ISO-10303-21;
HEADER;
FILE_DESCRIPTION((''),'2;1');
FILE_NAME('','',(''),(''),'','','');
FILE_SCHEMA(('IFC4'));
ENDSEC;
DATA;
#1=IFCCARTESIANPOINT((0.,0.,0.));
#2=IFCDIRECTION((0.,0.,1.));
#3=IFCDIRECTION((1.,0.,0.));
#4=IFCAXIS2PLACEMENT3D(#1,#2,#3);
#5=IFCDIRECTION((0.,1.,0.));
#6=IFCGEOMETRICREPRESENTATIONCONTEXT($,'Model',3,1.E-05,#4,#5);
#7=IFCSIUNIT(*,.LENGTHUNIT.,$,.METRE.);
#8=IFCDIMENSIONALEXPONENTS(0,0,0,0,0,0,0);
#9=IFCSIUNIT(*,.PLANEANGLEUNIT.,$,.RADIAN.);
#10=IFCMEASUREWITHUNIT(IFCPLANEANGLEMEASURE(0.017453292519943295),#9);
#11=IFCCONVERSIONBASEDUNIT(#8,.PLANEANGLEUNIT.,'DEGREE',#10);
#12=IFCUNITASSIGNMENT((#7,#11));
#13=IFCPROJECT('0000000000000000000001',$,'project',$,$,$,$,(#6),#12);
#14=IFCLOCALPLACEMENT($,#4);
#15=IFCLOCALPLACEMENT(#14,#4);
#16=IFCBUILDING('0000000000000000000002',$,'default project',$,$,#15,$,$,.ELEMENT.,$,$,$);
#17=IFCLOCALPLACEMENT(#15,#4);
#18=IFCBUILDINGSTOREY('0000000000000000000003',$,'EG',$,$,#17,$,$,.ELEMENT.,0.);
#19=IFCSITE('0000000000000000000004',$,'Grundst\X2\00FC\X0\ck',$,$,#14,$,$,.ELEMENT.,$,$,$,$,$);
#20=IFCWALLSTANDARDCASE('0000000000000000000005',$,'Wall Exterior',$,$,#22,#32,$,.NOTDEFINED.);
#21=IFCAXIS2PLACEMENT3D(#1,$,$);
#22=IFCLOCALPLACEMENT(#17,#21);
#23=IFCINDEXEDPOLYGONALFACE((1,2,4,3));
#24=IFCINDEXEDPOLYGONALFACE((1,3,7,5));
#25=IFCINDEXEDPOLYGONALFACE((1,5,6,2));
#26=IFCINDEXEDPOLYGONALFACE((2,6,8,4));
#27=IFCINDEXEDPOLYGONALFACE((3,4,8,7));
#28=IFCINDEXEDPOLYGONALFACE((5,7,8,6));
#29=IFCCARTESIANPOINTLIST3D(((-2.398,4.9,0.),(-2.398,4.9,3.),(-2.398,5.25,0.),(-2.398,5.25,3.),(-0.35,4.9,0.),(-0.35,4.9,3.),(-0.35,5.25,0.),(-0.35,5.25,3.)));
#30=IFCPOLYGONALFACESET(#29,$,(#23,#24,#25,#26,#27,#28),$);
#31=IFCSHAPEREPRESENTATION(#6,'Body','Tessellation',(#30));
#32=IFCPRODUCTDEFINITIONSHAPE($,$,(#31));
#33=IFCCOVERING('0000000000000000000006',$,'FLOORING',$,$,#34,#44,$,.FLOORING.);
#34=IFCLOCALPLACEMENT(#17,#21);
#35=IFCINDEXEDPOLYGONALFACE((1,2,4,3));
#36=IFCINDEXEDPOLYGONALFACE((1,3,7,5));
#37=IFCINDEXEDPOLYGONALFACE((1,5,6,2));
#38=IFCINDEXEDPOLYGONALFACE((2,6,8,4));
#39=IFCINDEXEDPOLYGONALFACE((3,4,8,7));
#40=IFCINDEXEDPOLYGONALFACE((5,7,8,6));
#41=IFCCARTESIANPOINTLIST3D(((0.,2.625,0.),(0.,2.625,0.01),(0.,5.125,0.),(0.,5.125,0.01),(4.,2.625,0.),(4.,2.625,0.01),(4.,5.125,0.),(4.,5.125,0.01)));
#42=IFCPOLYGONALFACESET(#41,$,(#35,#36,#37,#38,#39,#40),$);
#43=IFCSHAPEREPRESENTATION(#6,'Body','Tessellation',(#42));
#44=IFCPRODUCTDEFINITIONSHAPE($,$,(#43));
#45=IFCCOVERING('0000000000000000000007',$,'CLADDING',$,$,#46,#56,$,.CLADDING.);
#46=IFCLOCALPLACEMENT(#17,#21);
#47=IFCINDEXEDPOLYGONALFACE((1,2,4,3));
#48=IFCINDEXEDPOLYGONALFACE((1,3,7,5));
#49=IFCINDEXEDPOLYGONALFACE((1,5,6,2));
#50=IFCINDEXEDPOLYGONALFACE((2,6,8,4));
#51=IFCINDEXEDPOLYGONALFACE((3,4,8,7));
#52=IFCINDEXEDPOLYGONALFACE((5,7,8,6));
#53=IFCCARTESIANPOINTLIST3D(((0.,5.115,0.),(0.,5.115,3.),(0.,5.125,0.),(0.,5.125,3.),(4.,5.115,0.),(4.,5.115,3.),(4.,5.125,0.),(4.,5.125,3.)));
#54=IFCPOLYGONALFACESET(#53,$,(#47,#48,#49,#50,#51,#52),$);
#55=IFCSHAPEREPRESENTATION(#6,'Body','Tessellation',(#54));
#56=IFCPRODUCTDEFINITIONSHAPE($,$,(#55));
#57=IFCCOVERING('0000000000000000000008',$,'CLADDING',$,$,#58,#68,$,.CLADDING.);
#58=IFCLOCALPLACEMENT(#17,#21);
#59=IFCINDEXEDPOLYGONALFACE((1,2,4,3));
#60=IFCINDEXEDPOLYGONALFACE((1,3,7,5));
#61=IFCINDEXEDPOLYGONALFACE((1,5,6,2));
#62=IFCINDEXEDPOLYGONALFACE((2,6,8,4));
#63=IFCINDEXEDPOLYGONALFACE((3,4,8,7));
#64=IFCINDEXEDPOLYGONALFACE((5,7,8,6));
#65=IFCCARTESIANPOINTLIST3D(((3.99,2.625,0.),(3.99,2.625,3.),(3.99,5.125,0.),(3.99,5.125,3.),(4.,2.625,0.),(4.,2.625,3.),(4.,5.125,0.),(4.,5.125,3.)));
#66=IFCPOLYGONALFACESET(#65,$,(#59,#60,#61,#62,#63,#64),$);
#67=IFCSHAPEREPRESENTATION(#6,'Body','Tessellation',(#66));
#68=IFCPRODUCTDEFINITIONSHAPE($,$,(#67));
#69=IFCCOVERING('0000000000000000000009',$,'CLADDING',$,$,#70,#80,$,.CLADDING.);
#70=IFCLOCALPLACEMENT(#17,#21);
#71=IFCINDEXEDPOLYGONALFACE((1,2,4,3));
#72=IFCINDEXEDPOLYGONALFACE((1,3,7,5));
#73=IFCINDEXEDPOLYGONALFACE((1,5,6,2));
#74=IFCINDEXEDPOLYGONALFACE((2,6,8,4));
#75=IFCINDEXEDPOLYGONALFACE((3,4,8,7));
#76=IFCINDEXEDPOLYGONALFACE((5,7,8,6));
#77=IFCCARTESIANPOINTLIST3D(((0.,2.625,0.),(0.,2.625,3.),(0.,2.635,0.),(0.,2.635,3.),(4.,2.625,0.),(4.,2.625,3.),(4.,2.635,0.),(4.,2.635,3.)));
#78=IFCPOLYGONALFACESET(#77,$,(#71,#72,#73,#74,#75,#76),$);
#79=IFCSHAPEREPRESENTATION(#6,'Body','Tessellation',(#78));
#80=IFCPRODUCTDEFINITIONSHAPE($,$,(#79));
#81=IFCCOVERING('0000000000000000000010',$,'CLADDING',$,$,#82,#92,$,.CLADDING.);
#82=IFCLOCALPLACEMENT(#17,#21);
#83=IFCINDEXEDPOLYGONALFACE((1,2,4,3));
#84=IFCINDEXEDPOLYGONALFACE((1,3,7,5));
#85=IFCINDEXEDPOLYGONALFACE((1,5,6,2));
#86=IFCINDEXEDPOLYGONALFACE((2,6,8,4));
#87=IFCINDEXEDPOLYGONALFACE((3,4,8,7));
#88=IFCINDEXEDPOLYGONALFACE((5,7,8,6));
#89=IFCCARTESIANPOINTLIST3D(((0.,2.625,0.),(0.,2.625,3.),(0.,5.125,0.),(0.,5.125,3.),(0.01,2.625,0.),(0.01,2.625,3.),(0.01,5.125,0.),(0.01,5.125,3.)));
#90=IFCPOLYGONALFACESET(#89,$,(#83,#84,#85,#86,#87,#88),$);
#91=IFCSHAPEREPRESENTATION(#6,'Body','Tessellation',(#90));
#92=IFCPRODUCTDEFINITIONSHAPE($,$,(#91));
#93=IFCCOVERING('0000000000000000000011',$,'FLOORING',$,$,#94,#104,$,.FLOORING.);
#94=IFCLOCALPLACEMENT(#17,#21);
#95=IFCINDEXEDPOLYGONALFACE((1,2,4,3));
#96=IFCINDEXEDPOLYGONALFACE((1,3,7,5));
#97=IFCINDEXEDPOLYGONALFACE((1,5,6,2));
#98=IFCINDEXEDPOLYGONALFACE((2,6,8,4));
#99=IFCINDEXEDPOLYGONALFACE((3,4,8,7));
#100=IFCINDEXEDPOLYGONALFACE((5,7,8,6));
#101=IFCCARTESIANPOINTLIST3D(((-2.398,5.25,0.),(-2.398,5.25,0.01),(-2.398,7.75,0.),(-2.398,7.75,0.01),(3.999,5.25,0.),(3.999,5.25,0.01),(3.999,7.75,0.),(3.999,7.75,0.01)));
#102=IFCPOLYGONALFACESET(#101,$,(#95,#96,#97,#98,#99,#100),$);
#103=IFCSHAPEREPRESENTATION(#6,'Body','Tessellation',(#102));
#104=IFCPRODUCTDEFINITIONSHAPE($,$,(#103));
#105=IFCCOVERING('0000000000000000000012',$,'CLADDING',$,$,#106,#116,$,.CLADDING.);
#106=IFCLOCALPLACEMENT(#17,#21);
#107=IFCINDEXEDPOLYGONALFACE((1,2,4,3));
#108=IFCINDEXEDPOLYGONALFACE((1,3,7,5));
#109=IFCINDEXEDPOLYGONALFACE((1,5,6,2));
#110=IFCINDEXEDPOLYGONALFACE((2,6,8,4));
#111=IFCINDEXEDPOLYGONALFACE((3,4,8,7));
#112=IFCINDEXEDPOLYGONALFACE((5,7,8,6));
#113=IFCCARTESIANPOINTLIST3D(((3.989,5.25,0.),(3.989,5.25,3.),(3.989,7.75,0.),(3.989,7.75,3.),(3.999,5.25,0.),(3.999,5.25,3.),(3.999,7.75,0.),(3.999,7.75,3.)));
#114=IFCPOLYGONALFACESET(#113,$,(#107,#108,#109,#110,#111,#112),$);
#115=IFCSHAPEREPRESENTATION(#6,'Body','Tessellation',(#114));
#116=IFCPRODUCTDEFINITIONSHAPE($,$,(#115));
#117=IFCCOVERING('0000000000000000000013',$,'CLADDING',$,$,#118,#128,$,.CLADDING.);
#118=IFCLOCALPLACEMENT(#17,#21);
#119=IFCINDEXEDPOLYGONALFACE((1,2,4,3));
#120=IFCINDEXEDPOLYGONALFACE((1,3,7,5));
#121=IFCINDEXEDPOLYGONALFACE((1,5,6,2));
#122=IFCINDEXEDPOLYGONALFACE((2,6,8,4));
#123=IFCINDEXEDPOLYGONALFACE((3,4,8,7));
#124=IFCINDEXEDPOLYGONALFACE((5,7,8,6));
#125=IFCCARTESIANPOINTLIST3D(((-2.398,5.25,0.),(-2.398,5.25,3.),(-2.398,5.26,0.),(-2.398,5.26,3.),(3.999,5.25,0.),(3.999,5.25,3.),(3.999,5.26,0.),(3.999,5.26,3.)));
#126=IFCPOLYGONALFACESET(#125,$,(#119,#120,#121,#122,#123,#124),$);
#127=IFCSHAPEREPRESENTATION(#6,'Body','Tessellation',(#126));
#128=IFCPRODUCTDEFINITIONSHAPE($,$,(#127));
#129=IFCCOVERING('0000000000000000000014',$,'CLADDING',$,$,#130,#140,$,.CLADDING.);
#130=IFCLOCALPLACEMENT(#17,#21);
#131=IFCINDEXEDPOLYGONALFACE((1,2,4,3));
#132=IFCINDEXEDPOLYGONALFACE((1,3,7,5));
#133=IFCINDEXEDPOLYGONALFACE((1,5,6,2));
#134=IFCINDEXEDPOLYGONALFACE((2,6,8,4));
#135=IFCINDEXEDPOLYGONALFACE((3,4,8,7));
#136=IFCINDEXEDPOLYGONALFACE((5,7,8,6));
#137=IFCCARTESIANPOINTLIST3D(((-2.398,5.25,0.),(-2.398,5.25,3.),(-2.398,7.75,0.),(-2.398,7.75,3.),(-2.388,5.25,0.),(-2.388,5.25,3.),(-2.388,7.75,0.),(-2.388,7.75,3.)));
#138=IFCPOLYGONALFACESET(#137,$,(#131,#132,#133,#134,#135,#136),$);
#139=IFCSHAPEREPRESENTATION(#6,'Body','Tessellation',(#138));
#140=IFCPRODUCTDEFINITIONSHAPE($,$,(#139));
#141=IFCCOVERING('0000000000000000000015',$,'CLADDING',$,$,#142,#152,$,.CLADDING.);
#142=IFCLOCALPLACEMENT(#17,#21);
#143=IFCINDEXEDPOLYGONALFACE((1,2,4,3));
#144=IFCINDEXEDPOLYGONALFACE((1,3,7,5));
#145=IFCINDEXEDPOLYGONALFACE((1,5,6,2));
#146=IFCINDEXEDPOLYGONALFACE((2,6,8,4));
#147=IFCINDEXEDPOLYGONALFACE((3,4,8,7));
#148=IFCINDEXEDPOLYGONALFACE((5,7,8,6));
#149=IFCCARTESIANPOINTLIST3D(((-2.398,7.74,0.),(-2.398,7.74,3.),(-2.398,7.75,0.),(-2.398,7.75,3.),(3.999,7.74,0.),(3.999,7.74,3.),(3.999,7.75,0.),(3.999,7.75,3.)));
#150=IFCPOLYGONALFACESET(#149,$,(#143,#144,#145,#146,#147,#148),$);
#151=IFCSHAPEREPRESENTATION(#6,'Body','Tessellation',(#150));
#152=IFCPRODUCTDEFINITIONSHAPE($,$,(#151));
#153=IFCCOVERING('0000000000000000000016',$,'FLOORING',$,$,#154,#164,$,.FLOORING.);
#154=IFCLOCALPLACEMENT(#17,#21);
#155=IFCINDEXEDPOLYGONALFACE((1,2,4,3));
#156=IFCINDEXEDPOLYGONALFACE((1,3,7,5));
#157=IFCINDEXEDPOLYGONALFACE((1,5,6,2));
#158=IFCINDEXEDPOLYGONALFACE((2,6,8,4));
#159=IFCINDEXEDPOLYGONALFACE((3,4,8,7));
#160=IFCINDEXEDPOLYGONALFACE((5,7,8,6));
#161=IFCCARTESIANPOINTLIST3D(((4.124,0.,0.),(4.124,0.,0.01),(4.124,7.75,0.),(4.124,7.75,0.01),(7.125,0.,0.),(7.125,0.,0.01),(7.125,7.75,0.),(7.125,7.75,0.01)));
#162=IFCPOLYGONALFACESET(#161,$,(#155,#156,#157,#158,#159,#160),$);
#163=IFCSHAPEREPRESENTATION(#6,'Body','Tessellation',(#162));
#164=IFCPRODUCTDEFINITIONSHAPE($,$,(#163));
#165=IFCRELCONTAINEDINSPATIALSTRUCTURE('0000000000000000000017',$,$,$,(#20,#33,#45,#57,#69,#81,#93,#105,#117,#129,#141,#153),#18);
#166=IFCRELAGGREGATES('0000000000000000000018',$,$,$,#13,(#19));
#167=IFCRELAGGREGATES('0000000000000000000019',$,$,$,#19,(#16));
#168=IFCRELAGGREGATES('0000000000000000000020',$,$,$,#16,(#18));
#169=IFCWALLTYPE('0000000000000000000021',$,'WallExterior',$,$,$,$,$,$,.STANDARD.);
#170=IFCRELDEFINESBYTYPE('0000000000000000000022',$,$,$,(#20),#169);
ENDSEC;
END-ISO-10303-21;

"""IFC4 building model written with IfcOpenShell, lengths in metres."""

from ifc_helpers import new_model, entity, si_unit, converted_unit, direction, frame, origin_with_axes, place, context, project, spatial, polyline, outline, extrude, type_object, element, save


model = new_model("IFC4")

# Units and contexts
model_context = context("Model", 3, precision=1e-05, world=origin_with_axes(), true_north=direction((0.0, 1.0, 0.0)))
ifc_project = project(units=[si_unit("LENGTHUNIT", "METRE"), converted_unit("PLANEANGLEUNIT", "DEGREE", entity("IfcPlaneAngleMeasure", 0.017453292519943295), si_unit("PLANEANGLEUNIT", "RADIAN"), dimensions=[0, 0, 0, 0, 0, 0, 0])], contexts=[model_context])

# Site, building, storey
site_placement = place(None, origin_with_axes())
site = spatial("IfcSite", under=ifc_project, at=site_placement, Name="Grundstück", CompositionType="ELEMENT")
building_placement = place(site_placement, origin_with_axes())
building = spatial("IfcBuilding", under=site, at=building_placement, Name="default project", CompositionType="ELEMENT")
placement_1 = place(building_placement, origin_with_axes())
storey = spatial("IfcBuildingStorey", under=building, at=placement_1, Name="EG", CompositionType="ELEMENT", Elevation=0.0)

# Wall
wall_type_1 = type_object("IfcWallType", Name="WallExterior", PredefinedType="STANDARD")
placement_2 = place(placement_1, frame((-0.175, 5.075, 0.0), z_axis=(0.0, 0.0, 1.0), x_axis=(-1.0, 0.0, 0.0)))
element("IfcWallStandardCase", 1, at=placement_2, inside=storey, type_object=wall_type_1, Name="Wall Exterior", PredefinedType="NOTDEFINED", context=model_context, shape_type="SweptSolid", body=[
    extrude(outline(polyline([(0.175, -0.175), (2.223, -0.175), (2.223, 0.175), (0.175, 0.175), (0.175, -0.175)])), origin_with_axes(), (0.0, 0.0, 1.0), 3.0),
])

# Coverings
element("IfcCovering", 2, at=placement_1, inside=storey, Name="FLOORING", PredefinedType="FLOORING", context=model_context, shape_type="SweptSolid", body=[
    extrude(outline(polyline([(4.0, 5.125), (0.0, 5.125), (0.0, 2.625), (4.0, 2.625), (4.0, 5.125)])), origin_with_axes(), (0.0, 0.0, 1.0), 0.01),
])
element("IfcCovering", 3, at=placement_1, inside=storey, Name="CLADDING", PredefinedType="CLADDING", context=model_context, shape_type="SweptSolid", body=[
    extrude(outline(polyline([(0.0, 5.115), (4.0, 5.115), (4.0, 5.125), (0.0, 5.125), (0.0, 5.115)])), origin_with_axes(), (0.0, 0.0, 1.0), 3.0),
])
element("IfcCovering", 4, at=placement_1, inside=storey, Name="CLADDING", PredefinedType="CLADDING", context=model_context, shape_type="SweptSolid", body=[
    extrude(outline(polyline([(3.99, 5.125), (3.99, 2.625), (4.0, 2.625), (4.0, 5.125), (3.99, 5.125)])), origin_with_axes(), (0.0, 0.0, 1.0), 3.0),
])
element("IfcCovering", 5, at=placement_1, inside=storey, Name="CLADDING", PredefinedType="CLADDING", context=model_context, shape_type="SweptSolid", body=[
    extrude(outline(polyline([(4.0, 2.635), (0.0, 2.635), (0.0, 2.625), (4.0, 2.625), (4.0, 2.635)])), origin_with_axes(), (0.0, 0.0, 1.0), 3.0),
])
element("IfcCovering", 6, at=placement_1, inside=storey, Name="CLADDING", PredefinedType="CLADDING", context=model_context, shape_type="SweptSolid", body=[
    extrude(outline(polyline([(0.01, 2.625), (0.01, 5.125), (0.0, 5.125), (0.0, 2.625), (0.01, 2.625)])), origin_with_axes(), (0.0, 0.0, 1.0), 3.0),
])
element("IfcCovering", 7, at=placement_1, inside=storey, Name="FLOORING", PredefinedType="FLOORING", context=model_context, shape_type="SweptSolid", body=[
    extrude(outline(polyline([(3.999, 7.75), (-2.398, 7.75), (-2.398, 5.25), (3.999, 5.25), (3.999, 7.75)])), origin_with_axes(), (0.0, 0.0, 1.0), 0.01),
])
element("IfcCovering", 8, at=placement_1, inside=storey, Name="CLADDING", PredefinedType="CLADDING", context=model_context, shape_type="SweptSolid", body=[
    extrude(outline(polyline([(3.989, 7.75), (3.989, 5.25), (3.999, 5.25), (3.999, 7.75), (3.989, 7.75)])), origin_with_axes(), (0.0, 0.0, 1.0), 3.0),
])
element("IfcCovering", 9, at=placement_1, inside=storey, Name="CLADDING", PredefinedType="CLADDING", context=model_context, shape_type="SweptSolid", body=[
    extrude(outline(polyline([(3.999, 5.26), (-2.398, 5.26), (-2.398, 5.25), (3.999, 5.25), (3.999, 5.26)])), origin_with_axes(), (0.0, 0.0, 1.0), 3.0),
])
element("IfcCovering", 10, at=placement_1, inside=storey, Name="CLADDING", PredefinedType="CLADDING", context=model_context, shape_type="SweptSolid", body=[
    extrude(outline(polyline([(-2.388, 5.25), (-2.388, 7.75), (-2.398, 7.75), (-2.398, 5.25), (-2.388, 5.25)])), origin_with_axes(), (0.0, 0.0, 1.0), 3.0),
])
element("IfcCovering", 11, at=placement_1, inside=storey, Name="CLADDING", PredefinedType="CLADDING", context=model_context, shape_type="SweptSolid", body=[
    extrude(outline(polyline([(-2.398, 7.74), (3.999, 7.74), (3.999, 7.75), (-2.398, 7.75), (-2.398, 7.74)])), origin_with_axes(), (0.0, 0.0, 1.0), 3.0),
])
element("IfcCovering", 12, at=placement_1, inside=storey, Name="FLOORING", PredefinedType="FLOORING", context=model_context, shape_type="SweptSolid", body=[
    extrude(outline(polyline([(7.125, 7.75), (4.124, 7.75), (4.124, 0.0), (7.125, 0.0), (7.125, 7.75)])), origin_with_axes(), (0.0, 0.0, 1.0), 0.01),
])

save(model, "model.ifc")
